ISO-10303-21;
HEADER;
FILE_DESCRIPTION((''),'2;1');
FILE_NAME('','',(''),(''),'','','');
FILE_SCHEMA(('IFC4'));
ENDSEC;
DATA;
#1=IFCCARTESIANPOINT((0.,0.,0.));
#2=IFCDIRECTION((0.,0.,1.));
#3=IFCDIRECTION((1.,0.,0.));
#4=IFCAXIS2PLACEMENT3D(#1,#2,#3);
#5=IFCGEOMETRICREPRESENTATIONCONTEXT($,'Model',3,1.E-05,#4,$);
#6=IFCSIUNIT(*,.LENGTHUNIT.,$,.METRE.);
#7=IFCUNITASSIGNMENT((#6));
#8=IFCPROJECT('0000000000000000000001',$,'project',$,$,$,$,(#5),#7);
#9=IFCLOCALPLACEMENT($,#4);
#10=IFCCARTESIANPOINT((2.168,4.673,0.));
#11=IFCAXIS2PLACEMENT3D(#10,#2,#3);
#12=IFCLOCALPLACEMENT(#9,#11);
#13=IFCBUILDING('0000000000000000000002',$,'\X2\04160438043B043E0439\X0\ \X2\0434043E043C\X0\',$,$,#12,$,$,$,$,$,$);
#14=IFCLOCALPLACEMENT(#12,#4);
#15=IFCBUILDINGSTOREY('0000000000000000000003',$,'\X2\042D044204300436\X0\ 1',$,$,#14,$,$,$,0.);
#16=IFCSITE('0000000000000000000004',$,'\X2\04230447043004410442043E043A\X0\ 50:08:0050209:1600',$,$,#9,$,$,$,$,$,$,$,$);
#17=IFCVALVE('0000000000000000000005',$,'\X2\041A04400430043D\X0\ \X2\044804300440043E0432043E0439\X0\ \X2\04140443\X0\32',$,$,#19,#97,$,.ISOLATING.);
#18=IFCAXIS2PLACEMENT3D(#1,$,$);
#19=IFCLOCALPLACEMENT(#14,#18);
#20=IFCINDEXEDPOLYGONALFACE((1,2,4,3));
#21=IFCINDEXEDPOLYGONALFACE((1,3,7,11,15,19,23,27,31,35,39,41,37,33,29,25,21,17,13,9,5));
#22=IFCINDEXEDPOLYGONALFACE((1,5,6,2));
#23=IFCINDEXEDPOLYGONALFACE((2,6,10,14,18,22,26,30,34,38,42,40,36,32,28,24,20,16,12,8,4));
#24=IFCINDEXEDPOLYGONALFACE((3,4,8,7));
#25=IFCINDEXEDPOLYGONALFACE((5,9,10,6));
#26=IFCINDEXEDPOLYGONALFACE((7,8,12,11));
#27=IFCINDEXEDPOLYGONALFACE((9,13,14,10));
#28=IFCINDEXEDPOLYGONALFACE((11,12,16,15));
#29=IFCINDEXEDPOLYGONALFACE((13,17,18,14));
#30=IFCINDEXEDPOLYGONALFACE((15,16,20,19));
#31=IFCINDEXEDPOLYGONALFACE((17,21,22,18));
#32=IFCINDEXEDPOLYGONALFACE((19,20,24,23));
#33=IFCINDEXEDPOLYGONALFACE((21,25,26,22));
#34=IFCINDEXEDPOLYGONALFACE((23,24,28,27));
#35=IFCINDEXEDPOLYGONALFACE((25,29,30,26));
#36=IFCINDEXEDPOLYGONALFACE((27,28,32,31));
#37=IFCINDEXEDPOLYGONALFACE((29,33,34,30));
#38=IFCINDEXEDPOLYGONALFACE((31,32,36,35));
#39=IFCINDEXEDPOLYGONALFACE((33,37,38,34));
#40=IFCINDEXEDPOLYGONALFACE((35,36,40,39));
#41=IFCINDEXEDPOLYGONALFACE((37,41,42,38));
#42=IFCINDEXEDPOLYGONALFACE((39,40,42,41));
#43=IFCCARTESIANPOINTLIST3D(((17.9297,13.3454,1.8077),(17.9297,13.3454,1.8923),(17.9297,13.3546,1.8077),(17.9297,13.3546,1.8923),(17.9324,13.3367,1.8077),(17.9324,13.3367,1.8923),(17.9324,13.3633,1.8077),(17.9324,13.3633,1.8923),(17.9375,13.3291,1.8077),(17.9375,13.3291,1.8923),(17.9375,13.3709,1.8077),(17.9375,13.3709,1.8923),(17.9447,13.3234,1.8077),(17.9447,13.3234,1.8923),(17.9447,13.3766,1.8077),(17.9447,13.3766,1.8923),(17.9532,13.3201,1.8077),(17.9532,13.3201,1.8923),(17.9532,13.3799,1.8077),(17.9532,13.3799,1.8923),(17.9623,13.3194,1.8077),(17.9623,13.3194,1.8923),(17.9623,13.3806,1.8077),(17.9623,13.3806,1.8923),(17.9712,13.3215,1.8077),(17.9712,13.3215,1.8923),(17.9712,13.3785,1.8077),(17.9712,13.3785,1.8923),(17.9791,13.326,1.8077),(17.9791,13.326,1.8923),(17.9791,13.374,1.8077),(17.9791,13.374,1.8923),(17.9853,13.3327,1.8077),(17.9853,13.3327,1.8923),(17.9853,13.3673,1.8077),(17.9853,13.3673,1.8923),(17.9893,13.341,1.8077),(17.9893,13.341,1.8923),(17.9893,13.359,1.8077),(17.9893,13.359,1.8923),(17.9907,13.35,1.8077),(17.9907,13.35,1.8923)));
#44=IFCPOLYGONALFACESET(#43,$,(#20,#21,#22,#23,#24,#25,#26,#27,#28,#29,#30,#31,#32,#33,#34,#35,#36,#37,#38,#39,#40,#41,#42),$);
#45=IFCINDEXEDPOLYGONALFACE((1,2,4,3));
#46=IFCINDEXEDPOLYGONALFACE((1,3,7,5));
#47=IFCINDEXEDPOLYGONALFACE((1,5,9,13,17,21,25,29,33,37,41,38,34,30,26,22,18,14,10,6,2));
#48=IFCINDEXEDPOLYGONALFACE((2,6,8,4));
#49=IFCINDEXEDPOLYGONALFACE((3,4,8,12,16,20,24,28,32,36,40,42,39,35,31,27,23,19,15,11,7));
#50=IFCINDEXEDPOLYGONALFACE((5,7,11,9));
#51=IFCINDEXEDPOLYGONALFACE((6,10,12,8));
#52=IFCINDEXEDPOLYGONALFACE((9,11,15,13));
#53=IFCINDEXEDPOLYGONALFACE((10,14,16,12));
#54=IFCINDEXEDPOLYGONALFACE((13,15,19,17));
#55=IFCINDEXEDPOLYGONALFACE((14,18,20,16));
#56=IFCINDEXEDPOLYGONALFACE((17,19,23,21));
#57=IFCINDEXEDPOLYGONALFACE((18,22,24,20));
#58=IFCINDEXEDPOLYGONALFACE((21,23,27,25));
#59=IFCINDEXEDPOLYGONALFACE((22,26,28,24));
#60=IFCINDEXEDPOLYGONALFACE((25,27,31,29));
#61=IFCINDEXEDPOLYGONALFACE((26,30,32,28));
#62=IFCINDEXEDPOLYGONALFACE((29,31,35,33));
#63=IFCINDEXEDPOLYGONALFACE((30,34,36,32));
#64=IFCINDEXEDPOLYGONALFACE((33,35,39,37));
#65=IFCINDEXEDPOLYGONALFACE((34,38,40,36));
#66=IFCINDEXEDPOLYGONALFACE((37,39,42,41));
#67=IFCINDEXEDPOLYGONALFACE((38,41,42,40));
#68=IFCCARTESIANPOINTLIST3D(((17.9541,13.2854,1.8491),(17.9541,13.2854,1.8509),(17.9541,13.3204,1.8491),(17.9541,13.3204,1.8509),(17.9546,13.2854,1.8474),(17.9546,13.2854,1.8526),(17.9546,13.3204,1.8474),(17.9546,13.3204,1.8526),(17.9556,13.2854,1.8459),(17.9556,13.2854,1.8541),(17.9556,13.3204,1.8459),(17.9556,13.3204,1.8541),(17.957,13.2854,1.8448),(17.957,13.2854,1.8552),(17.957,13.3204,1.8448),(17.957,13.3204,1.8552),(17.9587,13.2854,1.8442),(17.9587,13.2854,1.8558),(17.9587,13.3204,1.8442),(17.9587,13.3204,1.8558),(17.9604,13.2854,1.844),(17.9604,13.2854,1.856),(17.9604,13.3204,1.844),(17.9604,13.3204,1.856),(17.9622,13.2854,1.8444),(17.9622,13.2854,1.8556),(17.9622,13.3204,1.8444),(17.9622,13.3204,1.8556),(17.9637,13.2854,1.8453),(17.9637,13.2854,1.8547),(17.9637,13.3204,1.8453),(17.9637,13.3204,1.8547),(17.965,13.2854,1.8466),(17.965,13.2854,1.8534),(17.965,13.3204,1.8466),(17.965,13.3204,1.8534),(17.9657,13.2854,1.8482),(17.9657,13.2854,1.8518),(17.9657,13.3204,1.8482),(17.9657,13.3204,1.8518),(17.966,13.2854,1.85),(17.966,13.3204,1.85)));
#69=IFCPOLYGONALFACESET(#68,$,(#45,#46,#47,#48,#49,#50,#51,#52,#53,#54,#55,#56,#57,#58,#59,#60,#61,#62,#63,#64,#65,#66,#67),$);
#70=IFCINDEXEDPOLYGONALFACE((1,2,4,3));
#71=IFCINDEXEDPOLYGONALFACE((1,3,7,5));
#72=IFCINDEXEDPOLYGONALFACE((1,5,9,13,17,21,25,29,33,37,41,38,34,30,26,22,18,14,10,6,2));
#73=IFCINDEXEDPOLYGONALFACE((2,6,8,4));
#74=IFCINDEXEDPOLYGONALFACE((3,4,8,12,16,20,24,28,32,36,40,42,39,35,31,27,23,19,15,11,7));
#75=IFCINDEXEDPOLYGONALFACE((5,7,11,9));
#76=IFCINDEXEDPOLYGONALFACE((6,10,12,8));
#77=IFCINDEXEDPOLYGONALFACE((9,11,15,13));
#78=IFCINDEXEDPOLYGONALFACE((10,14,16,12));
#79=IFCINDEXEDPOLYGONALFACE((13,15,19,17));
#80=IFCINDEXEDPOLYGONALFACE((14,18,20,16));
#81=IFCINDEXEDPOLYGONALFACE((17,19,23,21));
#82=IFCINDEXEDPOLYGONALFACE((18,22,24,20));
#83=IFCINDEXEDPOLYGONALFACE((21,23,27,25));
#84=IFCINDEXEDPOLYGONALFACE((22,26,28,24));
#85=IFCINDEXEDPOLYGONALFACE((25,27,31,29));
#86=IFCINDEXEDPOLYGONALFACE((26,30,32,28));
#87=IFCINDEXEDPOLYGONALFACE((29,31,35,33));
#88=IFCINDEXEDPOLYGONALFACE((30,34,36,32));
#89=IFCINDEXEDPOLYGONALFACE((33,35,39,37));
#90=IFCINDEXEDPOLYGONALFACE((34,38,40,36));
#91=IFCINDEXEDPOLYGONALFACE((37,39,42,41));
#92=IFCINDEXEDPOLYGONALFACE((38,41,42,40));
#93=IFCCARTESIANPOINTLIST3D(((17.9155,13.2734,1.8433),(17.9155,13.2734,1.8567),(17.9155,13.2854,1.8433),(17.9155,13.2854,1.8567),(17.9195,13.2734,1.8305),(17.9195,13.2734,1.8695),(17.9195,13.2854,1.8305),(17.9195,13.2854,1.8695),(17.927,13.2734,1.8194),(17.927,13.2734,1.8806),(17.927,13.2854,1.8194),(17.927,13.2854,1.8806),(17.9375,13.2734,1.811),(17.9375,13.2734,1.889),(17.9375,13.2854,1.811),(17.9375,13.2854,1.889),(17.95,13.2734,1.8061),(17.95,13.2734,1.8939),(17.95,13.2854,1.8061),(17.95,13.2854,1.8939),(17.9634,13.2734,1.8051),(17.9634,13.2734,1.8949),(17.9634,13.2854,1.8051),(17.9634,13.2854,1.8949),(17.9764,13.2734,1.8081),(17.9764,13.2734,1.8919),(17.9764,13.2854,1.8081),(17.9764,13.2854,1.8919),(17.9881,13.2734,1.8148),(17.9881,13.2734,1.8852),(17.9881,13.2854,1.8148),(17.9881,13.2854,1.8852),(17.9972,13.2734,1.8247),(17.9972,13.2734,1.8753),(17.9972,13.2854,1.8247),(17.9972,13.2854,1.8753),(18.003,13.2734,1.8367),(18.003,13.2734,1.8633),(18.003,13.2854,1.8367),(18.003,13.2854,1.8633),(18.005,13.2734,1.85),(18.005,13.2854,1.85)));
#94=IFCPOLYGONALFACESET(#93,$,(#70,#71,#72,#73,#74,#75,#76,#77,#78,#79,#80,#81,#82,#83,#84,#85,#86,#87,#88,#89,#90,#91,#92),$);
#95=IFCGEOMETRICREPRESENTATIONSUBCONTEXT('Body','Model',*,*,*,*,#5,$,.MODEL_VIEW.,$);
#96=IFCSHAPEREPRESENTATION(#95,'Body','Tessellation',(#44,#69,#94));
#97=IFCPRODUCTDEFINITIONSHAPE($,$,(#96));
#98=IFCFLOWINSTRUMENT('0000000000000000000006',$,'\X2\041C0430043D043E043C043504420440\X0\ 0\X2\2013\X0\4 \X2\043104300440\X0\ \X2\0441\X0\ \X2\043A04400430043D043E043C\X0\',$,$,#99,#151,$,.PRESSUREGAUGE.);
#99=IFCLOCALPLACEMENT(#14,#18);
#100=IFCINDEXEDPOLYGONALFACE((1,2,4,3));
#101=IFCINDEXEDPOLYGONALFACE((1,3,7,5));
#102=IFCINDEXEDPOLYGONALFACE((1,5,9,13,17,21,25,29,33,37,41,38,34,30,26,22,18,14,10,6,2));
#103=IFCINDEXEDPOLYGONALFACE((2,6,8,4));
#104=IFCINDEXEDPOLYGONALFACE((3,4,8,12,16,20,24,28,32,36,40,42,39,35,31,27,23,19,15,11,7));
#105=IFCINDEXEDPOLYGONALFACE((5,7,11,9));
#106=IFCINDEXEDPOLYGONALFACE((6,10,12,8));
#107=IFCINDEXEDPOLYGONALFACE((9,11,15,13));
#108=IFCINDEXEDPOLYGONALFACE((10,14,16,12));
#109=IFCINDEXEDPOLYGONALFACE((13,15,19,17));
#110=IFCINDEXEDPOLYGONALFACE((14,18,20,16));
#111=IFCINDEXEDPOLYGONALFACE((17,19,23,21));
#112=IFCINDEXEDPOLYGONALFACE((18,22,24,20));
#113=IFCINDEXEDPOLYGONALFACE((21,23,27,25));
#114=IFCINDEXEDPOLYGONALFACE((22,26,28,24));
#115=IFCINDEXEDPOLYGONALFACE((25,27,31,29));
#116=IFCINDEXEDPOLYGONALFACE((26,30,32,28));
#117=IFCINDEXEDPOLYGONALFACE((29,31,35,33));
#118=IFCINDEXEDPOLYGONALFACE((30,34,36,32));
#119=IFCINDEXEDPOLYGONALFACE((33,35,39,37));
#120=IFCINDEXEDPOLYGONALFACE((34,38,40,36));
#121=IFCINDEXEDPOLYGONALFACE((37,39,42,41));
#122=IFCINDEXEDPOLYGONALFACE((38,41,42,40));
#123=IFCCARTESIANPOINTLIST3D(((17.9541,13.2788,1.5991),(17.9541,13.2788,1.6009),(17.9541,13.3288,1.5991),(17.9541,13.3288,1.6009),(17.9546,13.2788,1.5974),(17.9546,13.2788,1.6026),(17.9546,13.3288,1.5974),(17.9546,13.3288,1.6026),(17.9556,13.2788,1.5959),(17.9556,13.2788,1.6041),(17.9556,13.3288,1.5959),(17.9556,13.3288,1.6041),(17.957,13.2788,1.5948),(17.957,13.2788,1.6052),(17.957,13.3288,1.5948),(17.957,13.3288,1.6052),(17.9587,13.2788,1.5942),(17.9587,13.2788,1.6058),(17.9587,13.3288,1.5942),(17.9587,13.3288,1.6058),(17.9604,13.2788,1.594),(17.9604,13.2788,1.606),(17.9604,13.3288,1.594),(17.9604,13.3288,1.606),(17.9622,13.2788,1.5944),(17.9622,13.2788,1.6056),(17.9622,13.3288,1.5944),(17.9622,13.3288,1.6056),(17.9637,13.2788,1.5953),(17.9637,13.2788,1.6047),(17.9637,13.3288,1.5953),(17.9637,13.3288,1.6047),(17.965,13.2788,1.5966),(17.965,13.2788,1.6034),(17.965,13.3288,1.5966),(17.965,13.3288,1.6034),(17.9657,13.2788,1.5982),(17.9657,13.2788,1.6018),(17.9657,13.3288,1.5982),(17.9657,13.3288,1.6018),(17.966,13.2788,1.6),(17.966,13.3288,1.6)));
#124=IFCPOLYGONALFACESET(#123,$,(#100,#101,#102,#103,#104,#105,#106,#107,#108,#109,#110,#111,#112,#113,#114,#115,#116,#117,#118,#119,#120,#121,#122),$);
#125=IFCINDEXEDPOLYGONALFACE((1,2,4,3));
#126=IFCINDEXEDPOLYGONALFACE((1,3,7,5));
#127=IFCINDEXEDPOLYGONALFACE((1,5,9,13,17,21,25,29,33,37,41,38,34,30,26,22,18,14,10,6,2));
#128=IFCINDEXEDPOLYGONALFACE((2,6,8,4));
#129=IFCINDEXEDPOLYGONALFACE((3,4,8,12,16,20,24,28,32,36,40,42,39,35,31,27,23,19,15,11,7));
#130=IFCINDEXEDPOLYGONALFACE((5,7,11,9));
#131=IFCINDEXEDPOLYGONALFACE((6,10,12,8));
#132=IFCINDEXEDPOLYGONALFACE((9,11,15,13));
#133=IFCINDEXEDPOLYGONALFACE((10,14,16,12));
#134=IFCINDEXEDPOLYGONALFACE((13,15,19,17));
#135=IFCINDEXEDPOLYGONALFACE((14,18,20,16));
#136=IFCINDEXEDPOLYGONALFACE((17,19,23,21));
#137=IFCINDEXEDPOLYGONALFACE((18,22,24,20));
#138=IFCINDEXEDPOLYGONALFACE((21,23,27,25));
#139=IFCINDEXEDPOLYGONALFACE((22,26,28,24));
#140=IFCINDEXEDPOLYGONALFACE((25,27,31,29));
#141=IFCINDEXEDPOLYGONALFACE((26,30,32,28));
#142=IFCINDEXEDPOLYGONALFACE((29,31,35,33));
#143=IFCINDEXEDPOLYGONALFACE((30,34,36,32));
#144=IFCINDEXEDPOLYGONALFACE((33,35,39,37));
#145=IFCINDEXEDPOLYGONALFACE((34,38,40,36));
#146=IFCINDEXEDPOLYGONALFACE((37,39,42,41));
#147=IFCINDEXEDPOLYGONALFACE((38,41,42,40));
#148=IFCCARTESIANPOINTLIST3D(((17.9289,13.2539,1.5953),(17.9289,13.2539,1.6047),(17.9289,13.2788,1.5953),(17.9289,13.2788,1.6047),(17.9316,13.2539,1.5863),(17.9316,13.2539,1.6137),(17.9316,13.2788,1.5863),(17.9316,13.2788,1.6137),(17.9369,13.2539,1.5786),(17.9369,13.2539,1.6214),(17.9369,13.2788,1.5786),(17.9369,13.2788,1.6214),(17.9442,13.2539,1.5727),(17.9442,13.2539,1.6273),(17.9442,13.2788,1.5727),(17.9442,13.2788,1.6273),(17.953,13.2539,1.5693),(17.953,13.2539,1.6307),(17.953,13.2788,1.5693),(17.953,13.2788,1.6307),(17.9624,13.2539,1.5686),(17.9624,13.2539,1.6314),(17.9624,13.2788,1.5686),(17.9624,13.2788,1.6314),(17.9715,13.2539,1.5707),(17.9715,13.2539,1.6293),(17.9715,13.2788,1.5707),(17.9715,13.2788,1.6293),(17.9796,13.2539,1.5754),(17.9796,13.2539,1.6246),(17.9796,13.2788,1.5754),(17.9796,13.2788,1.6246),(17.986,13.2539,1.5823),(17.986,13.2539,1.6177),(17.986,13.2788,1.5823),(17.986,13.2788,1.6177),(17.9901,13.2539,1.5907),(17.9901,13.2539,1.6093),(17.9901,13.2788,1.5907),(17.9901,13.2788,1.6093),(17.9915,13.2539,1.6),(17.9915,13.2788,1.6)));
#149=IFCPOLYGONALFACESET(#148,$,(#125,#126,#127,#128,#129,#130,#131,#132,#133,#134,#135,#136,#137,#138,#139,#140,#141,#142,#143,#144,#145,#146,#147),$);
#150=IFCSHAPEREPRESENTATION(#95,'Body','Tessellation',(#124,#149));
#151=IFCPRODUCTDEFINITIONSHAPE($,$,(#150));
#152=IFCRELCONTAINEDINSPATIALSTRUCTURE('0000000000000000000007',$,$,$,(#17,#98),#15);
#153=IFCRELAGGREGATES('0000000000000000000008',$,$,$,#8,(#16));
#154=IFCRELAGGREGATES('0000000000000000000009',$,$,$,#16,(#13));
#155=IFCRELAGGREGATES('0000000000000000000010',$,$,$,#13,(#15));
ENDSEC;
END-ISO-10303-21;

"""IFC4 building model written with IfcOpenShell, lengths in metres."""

from ifc_helpers import new_model, si_unit, frame, origin_with_axes, origin_2d, place, context, subcontext, project, spatial, circle, extrude, element, save


model = new_model("IFC4")

# Units and contexts
model_context = context("Model", 3, precision=1e-05, world=origin_with_axes())
body_context = subcontext(model_context, "Body", "Model", "MODEL_VIEW")
ifc_project = project(units=[si_unit("LENGTHUNIT", "METRE")], contexts=[model_context])

# Site, building, storey
site_placement = place(None, origin_with_axes())
site = spatial("IfcSite", under=ifc_project, at=site_placement, Name="Участок 50:08:0050209:1600")
building_placement = place(site_placement, frame((2.168, 4.673, 0.0), z_axis=(0.0, 0.0, 1.0), x_axis=(1.0, 0.0, 0.0)))
building = spatial("IfcBuilding", under=site, at=building_placement, Name="Жилой дом")
storey_placement = place(building_placement, origin_with_axes())
storey = spatial("IfcBuildingStorey", under=building, at=storey_placement, Name="Этаж 1", Elevation=0.0)

# Valve
valve_1_placement = place(storey_placement, origin_with_axes())
element("IfcValve", 1, at=valve_1_placement, inside=storey, Name="Кран шаровой Ду32", PredefinedType="ISOLATING", context=body_context, shape_type="SweptSolid", body=[
    extrude(circle(Radius=0.0307, at=origin_2d()), frame((17.96, 13.35, 1.8077), z_axis=(0.0, 0.0, 1.0), x_axis=(1.0, 0.0, 0.0)), (0.0, 0.0, 1.0), 0.0846),
    extrude(circle(Radius=0.006, at=origin_2d()), frame((17.96, 13.3204, 1.85), z_axis=(0.0, -1.0, 0.0), x_axis=(1.0, 0.0, 0.0)), (0.0, 0.0, 1.0), 0.035),
    extrude(circle(Radius=0.045, at=origin_2d()), frame((17.96, 13.2854, 1.85), z_axis=(0.0, -1.0, 0.0), x_axis=(1.0, 0.0, 0.0)), (0.0, 0.0, 1.0), 0.012),
])

# Flow instrument
flow_instrument_1_placement = place(storey_placement, origin_with_axes())
element("IfcFlowInstrument", 2, at=flow_instrument_1_placement, inside=storey, Name="Манометр 0–4 бар с краном", PredefinedType="PRESSUREGAUGE", context=body_context, shape_type="SweptSolid", body=[
    extrude(circle(Radius=0.006, at=origin_2d()), frame((17.96, 13.3288, 1.6), z_axis=(0.0, -1.0, 0.0), x_axis=(1.0, 0.0, 0.0)), (0.0, 0.0, 1.0), 0.05),
    extrude(circle(Radius=0.0315, at=origin_2d()), frame((17.96, 13.2789, 1.6), z_axis=(0.0, -1.0, 0.0), x_axis=(1.0, 0.0, 0.0)), (0.0, 0.0, 1.0), 0.025),
])

save(model, "model.ifc")
